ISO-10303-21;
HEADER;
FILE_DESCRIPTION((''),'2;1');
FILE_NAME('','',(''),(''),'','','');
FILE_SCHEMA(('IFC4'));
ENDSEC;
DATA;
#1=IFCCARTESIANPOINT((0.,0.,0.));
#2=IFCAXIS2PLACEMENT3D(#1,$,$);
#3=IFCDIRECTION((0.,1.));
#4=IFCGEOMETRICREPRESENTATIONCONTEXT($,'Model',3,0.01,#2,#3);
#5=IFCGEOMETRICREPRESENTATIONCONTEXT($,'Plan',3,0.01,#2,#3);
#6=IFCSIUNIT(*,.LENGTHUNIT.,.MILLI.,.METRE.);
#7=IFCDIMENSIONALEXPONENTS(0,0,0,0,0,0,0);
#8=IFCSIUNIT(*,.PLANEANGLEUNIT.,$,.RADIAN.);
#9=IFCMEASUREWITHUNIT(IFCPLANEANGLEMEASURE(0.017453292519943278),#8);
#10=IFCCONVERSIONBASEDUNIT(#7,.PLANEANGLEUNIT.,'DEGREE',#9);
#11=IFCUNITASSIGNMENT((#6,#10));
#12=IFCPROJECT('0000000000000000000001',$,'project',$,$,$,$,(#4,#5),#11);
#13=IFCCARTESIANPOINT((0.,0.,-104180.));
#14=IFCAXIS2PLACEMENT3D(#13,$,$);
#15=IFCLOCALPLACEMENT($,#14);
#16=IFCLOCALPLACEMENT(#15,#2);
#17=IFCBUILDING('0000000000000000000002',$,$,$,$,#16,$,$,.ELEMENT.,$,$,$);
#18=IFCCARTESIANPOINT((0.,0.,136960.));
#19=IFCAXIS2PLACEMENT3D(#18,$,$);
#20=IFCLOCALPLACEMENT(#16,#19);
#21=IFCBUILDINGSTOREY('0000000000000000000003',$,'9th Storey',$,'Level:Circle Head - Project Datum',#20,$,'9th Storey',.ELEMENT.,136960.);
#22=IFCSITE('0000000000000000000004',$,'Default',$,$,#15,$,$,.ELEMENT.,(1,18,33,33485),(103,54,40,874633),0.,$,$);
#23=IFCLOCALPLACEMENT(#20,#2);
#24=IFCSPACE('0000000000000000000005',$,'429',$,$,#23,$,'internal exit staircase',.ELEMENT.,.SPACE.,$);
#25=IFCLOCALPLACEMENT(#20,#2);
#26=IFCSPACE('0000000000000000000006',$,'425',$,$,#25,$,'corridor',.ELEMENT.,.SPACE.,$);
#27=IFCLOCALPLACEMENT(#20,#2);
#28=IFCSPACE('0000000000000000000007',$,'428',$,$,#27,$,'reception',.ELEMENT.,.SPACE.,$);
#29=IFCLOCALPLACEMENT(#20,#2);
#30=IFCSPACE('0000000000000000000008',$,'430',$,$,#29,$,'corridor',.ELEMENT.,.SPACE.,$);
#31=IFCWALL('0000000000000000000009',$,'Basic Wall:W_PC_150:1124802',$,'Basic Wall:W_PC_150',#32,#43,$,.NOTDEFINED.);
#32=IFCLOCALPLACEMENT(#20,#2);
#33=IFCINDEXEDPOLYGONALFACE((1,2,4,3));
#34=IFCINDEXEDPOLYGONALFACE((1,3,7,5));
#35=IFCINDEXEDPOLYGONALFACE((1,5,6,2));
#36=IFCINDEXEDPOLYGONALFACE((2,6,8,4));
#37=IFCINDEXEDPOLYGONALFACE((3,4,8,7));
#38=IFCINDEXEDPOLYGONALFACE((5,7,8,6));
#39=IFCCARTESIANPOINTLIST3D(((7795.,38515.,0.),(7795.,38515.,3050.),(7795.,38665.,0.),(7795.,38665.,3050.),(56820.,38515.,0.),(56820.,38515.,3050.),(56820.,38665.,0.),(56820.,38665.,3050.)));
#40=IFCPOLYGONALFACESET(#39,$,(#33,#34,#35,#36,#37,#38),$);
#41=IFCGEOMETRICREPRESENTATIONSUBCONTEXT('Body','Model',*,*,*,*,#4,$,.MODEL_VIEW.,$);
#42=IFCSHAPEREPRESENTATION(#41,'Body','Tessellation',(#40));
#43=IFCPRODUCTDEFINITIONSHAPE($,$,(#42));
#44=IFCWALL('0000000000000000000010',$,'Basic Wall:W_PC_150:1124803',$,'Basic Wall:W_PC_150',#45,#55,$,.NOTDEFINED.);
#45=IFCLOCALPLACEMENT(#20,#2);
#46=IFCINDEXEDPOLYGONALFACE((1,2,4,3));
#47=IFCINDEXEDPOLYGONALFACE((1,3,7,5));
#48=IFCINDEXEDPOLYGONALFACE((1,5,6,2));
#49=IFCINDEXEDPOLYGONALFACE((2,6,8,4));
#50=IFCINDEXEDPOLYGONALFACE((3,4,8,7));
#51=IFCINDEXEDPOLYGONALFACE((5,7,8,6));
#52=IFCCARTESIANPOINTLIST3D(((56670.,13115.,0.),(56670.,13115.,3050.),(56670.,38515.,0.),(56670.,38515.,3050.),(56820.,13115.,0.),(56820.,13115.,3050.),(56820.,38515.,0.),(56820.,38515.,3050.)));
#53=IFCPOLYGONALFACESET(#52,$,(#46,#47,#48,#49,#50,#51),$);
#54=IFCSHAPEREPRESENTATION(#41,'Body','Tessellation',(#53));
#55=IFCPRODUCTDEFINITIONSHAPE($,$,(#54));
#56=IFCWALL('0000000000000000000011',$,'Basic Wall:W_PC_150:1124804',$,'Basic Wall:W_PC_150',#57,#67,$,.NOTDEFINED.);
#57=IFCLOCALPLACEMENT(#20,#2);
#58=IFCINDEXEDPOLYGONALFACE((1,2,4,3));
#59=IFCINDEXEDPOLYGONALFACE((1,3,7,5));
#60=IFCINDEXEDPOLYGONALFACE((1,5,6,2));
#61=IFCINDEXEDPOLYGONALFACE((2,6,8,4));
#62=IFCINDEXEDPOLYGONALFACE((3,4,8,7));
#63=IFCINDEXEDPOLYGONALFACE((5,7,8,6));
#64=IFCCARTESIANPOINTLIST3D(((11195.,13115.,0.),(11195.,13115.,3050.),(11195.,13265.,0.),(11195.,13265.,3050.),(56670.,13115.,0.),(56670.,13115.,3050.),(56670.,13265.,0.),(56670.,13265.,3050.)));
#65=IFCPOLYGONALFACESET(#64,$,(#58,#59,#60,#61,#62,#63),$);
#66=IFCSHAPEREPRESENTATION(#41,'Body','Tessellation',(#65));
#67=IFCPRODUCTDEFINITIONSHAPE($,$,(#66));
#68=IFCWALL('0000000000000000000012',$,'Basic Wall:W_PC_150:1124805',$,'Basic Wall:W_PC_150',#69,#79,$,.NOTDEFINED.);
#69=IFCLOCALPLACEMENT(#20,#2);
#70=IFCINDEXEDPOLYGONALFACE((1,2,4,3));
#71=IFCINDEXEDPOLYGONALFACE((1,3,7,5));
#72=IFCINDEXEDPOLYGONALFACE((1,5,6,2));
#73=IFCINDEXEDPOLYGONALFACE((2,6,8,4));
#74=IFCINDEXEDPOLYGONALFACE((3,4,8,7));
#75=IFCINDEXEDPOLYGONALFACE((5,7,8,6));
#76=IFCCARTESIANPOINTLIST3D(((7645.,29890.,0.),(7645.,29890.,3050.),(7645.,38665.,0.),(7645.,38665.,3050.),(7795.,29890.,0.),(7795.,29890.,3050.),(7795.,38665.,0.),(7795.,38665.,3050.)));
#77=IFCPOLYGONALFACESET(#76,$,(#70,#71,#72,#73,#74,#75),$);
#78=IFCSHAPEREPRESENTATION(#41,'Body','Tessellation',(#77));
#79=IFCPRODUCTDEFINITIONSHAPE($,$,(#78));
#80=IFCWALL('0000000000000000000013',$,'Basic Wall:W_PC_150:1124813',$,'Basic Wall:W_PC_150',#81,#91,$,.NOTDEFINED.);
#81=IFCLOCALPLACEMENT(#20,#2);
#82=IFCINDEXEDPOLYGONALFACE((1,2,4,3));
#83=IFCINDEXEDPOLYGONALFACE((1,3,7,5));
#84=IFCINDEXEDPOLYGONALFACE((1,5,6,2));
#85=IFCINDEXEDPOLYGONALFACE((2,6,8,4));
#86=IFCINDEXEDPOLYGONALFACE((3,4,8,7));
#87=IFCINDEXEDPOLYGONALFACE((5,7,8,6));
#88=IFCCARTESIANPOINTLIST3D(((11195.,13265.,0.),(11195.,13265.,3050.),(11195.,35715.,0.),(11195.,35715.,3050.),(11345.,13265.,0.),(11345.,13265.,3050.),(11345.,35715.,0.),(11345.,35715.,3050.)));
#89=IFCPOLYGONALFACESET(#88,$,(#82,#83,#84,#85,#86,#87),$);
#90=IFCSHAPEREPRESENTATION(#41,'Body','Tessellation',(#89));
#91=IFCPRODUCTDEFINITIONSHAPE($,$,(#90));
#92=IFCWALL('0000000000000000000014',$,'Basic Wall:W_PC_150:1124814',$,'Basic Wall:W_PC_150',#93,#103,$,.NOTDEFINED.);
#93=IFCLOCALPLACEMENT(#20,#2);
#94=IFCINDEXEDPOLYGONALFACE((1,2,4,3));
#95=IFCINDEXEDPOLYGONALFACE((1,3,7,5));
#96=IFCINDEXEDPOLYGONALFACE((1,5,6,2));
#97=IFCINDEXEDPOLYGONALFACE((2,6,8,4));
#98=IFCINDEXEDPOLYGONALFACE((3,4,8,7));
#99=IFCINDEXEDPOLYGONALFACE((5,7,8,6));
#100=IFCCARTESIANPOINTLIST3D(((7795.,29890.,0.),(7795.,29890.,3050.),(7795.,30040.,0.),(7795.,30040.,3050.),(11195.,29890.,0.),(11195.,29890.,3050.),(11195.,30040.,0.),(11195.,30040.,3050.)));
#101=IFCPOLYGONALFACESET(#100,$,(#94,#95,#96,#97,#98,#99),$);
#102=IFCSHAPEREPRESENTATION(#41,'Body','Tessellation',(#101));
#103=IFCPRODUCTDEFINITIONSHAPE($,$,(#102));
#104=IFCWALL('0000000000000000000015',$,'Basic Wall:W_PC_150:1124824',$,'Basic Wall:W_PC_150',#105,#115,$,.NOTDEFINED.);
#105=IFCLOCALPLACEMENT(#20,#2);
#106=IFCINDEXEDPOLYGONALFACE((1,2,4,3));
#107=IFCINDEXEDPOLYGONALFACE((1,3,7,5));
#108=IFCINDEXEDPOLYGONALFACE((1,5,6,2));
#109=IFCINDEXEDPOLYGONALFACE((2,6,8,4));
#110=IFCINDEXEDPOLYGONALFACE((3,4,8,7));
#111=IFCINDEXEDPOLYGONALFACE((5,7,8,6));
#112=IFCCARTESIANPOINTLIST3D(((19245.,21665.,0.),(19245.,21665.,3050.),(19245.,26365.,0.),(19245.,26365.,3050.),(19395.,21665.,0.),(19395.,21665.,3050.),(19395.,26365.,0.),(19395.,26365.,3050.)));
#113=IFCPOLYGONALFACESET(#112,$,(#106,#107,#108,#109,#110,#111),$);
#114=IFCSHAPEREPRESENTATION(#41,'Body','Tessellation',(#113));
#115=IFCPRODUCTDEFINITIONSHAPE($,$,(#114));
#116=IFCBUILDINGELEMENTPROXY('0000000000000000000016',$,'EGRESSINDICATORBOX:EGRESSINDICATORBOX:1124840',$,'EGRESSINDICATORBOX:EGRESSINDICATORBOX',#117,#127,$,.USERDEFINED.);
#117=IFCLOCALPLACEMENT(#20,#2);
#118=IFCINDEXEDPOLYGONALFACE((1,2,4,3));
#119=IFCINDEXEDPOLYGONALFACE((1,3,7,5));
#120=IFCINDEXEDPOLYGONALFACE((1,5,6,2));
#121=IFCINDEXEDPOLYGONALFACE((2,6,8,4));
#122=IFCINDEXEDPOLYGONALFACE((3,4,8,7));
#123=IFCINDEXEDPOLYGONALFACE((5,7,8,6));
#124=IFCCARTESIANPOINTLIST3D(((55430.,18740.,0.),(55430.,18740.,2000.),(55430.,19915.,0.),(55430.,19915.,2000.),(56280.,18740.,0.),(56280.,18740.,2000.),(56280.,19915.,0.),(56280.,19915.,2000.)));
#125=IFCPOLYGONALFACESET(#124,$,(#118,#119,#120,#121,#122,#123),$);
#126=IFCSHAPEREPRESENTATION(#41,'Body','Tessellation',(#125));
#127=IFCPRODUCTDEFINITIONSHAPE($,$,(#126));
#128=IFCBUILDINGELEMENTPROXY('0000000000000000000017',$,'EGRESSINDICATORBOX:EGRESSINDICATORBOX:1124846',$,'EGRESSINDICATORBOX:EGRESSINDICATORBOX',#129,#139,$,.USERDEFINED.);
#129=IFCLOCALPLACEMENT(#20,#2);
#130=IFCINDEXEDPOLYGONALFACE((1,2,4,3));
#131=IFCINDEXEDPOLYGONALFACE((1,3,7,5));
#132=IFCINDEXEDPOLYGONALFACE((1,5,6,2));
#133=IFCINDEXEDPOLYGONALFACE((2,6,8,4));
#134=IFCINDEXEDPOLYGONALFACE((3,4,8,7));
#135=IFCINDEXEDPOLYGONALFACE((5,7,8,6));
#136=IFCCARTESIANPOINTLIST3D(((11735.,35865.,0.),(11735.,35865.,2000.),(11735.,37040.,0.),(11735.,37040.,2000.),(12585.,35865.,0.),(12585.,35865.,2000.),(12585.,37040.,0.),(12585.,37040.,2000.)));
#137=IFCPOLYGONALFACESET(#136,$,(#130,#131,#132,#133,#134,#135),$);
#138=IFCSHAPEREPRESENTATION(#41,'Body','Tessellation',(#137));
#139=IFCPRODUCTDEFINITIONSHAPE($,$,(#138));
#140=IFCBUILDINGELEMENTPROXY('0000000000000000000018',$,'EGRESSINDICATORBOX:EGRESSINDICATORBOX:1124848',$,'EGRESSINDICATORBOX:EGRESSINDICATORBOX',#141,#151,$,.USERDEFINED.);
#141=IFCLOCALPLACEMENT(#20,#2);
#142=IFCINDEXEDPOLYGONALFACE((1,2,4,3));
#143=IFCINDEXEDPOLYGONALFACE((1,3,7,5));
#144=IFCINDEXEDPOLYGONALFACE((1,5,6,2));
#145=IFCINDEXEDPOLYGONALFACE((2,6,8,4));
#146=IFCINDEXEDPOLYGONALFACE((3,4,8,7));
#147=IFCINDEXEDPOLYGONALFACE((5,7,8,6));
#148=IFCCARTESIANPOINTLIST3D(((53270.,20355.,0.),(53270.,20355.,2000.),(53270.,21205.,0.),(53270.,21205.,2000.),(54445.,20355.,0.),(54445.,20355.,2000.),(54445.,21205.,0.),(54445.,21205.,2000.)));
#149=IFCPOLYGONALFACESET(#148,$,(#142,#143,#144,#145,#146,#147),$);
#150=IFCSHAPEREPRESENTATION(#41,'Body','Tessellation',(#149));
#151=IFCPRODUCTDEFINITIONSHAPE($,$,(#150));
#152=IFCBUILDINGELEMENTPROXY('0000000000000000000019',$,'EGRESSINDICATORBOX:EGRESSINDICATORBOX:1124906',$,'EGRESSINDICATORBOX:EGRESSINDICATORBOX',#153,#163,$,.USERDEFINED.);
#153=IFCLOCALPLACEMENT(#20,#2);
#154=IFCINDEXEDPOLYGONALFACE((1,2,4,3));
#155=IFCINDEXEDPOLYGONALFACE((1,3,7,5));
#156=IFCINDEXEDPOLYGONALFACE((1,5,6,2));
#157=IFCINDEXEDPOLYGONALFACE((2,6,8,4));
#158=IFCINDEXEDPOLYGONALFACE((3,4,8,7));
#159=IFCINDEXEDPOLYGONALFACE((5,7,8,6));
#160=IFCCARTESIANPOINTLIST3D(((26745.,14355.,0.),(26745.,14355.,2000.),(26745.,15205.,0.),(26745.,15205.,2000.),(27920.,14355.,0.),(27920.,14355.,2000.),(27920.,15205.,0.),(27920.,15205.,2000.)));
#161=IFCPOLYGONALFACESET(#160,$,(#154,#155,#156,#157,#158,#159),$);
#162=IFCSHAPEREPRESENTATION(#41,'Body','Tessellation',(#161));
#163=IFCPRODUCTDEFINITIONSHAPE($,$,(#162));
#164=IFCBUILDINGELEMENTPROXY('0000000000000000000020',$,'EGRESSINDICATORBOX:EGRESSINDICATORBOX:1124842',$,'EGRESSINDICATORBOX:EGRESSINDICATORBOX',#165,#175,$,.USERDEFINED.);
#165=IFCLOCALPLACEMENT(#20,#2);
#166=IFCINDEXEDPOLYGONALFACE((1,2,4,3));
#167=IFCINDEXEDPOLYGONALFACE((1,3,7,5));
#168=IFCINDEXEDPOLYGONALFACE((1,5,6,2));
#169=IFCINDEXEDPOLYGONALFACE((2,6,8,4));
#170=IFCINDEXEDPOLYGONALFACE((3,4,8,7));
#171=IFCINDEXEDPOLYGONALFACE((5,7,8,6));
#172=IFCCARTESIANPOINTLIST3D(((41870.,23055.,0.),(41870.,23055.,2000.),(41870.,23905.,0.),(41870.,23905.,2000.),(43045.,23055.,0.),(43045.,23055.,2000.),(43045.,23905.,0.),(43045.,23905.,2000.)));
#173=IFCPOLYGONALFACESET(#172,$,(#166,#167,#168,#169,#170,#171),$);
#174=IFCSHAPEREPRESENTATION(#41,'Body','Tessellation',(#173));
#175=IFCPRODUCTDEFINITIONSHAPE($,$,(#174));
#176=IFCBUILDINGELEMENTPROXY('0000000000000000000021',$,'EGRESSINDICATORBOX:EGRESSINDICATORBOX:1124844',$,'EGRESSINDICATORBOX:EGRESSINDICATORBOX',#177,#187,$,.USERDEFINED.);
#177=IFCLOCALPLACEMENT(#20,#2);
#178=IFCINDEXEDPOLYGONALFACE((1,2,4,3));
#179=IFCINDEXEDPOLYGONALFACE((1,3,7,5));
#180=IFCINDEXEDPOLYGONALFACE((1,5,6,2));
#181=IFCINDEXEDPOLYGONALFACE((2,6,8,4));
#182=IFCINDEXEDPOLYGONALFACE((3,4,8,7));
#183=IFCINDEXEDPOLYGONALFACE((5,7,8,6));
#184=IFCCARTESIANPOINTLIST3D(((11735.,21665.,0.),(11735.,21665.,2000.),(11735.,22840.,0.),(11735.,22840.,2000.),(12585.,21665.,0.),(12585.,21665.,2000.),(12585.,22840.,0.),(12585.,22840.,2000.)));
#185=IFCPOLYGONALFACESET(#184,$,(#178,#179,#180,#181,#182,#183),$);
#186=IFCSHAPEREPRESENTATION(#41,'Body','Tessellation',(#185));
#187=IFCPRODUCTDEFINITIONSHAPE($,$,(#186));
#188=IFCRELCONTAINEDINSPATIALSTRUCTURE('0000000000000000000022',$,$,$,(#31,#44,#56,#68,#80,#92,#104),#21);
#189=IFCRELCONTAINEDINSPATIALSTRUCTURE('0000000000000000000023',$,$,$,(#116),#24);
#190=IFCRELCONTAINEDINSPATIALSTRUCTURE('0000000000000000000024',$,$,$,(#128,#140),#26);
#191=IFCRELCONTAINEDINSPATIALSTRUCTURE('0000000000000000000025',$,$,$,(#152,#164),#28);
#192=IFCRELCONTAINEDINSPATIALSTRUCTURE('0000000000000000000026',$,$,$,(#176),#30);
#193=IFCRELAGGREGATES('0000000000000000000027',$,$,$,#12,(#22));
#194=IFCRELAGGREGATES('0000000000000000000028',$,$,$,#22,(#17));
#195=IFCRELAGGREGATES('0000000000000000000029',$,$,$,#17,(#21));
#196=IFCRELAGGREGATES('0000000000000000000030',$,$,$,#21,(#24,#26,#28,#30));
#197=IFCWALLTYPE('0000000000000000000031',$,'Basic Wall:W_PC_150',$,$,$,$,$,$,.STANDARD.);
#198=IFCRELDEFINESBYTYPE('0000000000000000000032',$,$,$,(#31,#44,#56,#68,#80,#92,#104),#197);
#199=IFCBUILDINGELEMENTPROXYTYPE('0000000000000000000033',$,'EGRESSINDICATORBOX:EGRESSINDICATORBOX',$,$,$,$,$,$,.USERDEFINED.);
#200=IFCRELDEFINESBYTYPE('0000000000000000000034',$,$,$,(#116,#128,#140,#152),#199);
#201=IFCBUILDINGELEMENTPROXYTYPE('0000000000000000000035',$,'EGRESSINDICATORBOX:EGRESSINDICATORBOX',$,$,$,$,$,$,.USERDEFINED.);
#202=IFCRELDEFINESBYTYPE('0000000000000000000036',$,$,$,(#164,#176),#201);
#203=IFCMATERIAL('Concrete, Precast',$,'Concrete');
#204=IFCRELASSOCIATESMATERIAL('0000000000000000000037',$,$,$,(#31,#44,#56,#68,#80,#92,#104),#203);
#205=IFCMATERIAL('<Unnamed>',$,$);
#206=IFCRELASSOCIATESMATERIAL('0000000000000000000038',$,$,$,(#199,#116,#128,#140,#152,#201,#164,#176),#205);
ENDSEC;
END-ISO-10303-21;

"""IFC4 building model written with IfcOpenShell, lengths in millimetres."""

from ifc_helpers import new_model, entity, si_unit, converted_unit, direction, frame, origin, place, context, subcontext, project, spatial, indexed_curve, outline, extrude, source, transform, mapped, material, type_object, type_shapes, element, save


model = new_model("IFC4")

# Units and contexts
model_context = context("Model", 3, precision=0.01, world=origin(), true_north=direction((0.0, 1.0)))
plan_context = context("Plan", 3, precision=0.01, world=origin(), true_north=direction((0.0, 1.0)))
body_context = subcontext(model_context, "Body", "Model", "MODEL_VIEW")
ifc_project = project(units=[si_unit("LENGTHUNIT", "METRE", prefix="MILLI"), converted_unit("PLANEANGLEUNIT", "DEGREE", entity("IfcPlaneAngleMeasure", 0.017453292519943278), si_unit("PLANEANGLEUNIT", "RADIAN"), dimensions=[0, 0, 0, 0, 0, 0, 0])], contexts=[model_context, plan_context])

# Site, building, storey
site_placement = place(None, frame((0.0, 0.0, -104180.0)))
site = spatial("IfcSite", under=ifc_project, at=site_placement, Name="Default", CompositionType="ELEMENT", RefLatitude=(1, 18, 33, 33485), RefLongitude=(103, 54, 40, 874633), RefElevation=0.0)
building_placement = place(site_placement, origin())
building = spatial("IfcBuilding", under=site, at=building_placement, CompositionType="ELEMENT")
storey_placement = place(building_placement, frame((0.0, 0.0, 136960.0)))
storey = spatial("IfcBuildingStorey", under=building, at=storey_placement, Name="9th Storey", ObjectType="Level:Circle Head - Project Datum", LongName="9th Storey", CompositionType="ELEMENT", Elevation=136960.0)

# Shared definitions
ifc_material_1 = material(Name="Concrete, Precast", Category="Concrete")

# Walls
wall_type = type_object("IfcWallType", Name="Basic Wall:W_PC_150", PredefinedType="STANDARD")
wall_1_placement = place(storey_placement, frame((56820.0, 38590.0, 0.0), z_axis=(0.0, 0.0, 1.0), x_axis=(-1.0, 0.0, 0.0)))
element("IfcWall", 1, at=wall_1_placement, inside=storey, type_object=wall_type, material=ifc_material_1, Name="Basic Wall:W_PC_150:1124802", ObjectType="Basic Wall:W_PC_150", PredefinedType="NOTDEFINED", context=body_context, shape_type="SweptSolid", body=[
    extrude(outline(indexed_curve([(49025.0, 75.0), (0.0, 75.0), (0.0, -75.0), (49025.0, -75.0), (49025.0, 75.0)], self_intersect=False)), origin(), (0.0, 0.0, 1.0), 3050.0),
])
wall_2_placement = place(storey_placement, frame((56745.0, 13115.0, 0.0), z_axis=(0.0, 0.0, 1.0), x_axis=(0.0, 1.0, 0.0)))
element("IfcWall", 2, at=wall_2_placement, inside=storey, type_object=wall_type, material=ifc_material_1, Name="Basic Wall:W_PC_150:1124803", ObjectType="Basic Wall:W_PC_150", PredefinedType="NOTDEFINED", context=body_context, shape_type="SweptSolid", body=[
    extrude(outline(indexed_curve([(25400.0, 75.0), (0.0, 75.0), (0.0, -75.0), (25400.0, -75.0), (25400.0, 75.0)], self_intersect=False)), origin(), (0.0, 0.0, 1.0), 3050.0),
])
wall_3_placement = place(storey_placement, frame((11195.0, 13190.0, 0.0)))
element("IfcWall", 3, at=wall_3_placement, inside=storey, type_object=wall_type, material=ifc_material_1, Name="Basic Wall:W_PC_150:1124804", ObjectType="Basic Wall:W_PC_150", PredefinedType="NOTDEFINED", context=body_context, shape_type="SweptSolid", body=[
    extrude(outline(indexed_curve([(45475.0, 75.0), (0.0, 75.0), (0.0, -75.0), (45475.0, -75.0), (45475.0, 75.0)], self_intersect=False)), origin(), (0.0, 0.0, 1.0), 3050.0),
])
wall_4_placement = place(storey_placement, frame((7720.0, 38665.0, 0.0), z_axis=(0.0, 0.0, 1.0), x_axis=(0.0, -1.0, 0.0)))
element("IfcWall", 4, at=wall_4_placement, inside=storey, type_object=wall_type, material=ifc_material_1, Name="Basic Wall:W_PC_150:1124805", ObjectType="Basic Wall:W_PC_150", PredefinedType="NOTDEFINED", context=body_context, shape_type="SweptSolid", body=[
    extrude(outline(indexed_curve([(8775.0, 75.0), (0.0, 75.0), (0.0, -75.0), (8775.0, -75.0), (8775.0, 75.0)], self_intersect=False)), origin(), (0.0, 0.0, 1.0), 3050.0),
])
wall_5_placement = place(storey_placement, frame((11270.0, 35715.0, 0.0), z_axis=(0.0, 0.0, 1.0), x_axis=(0.0, -1.0, 0.0)))
element("IfcWall", 5, at=wall_5_placement, inside=storey, type_object=wall_type, material=ifc_material_1, Name="Basic Wall:W_PC_150:1124813", ObjectType="Basic Wall:W_PC_150", PredefinedType="NOTDEFINED", context=body_context, shape_type="SweptSolid", body=[
    extrude(outline(indexed_curve([(22450.0, 75.0), (0.0, 75.0), (0.0, -75.0), (22450.0, -75.0), (22450.0, 75.0)], self_intersect=False)), origin(), (0.0, 0.0, 1.0), 3050.0),
])
wall_6_placement = place(storey_placement, frame((7795.0, 29965.0, 0.0)))
element("IfcWall", 6, at=wall_6_placement, inside=storey, type_object=wall_type, material=ifc_material_1, Name="Basic Wall:W_PC_150:1124814", ObjectType="Basic Wall:W_PC_150", PredefinedType="NOTDEFINED", context=body_context, shape_type="SweptSolid", body=[
    extrude(outline(indexed_curve([(3400.0, 75.0), (0.0, 75.0), (0.0, -75.0), (3400.0, -75.0), (3400.0, 75.0)], self_intersect=False)), origin(), (0.0, 0.0, 1.0), 3050.0),
])
wall_7_placement = place(storey_placement, frame((19320.0, 21665.0, 0.0), z_axis=(0.0, 0.0, 1.0), x_axis=(0.0, 1.0, 0.0)))
element("IfcWall", 7, at=wall_7_placement, inside=storey, type_object=wall_type, material=ifc_material_1, Name="Basic Wall:W_PC_150:1124824", ObjectType="Basic Wall:W_PC_150", PredefinedType="NOTDEFINED", context=body_context, shape_type="SweptSolid", body=[
    extrude(outline(indexed_curve([(4700.0, 75.0), (0.0, 75.0), (0.0, -75.0), (4700.0, -75.0), (4700.0, 75.0)], self_intersect=False)), origin(), (0.0, 0.0, 1.0), 3050.0),
])

# Shared definitions
space_1_placement = place(storey_placement, origin())
space_1 = spatial("IfcSpace", under=storey, at=space_1_placement, Name="429", LongName="internal exit staircase", CompositionType="ELEMENT", PredefinedType="SPACE")

# Building element proxy
ifc_material_2 = material(Name="<Unnamed>")
building_element_proxy_type_1 = type_object("IfcBuildingElementProxyType", Name="EGRESSINDICATORBOX:EGRESSINDICATORBOX", PredefinedType="USERDEFINED", material=ifc_material_2)
shared_shape_1 = source(origin(), body_context, "Body", "SweptSolid", [
    extrude(outline(indexed_curve([(-587.5, -425.0), (587.5, -425.0), (587.5, 425.0), (-587.5, 425.0), (-587.5, -425.0)], self_intersect=False)), frame((0.0, 0.0, 0.0), z_axis=(0.0, 0.0, 1.0), x_axis=(0.0, 1.0, 0.0)), (0.0, 0.0, 1.0), 2000.0),
])
type_shapes(building_element_proxy_type_1, [shared_shape_1])
proxy_1_placement = place(space_1_placement, frame((55855.0, 19327.5, 0.0)))
element("IfcBuildingElementProxy", 8, at=proxy_1_placement, inside=space_1, type_object=building_element_proxy_type_1, material=ifc_material_2, Name="EGRESSINDICATORBOX:EGRESSINDICATORBOX:1124840", ObjectType="EGRESSINDICATORBOX:EGRESSINDICATORBOX", PredefinedType="USERDEFINED", context=body_context, shape_type="MappedRepresentation", body=[
    mapped(shared_shape_1, transform((0.0, 0.0, 0.0), scale=1.0)),
])

# Shared definitions
space_2_placement = place(storey_placement, origin())
space_2 = spatial("IfcSpace", under=storey, at=space_2_placement, Name="425", LongName="corridor", CompositionType="ELEMENT", PredefinedType="SPACE")

# Building element proxies
for number, where, z_axis, x_axis, name in (
    (9, (12160.0, 36452.5, 0.0), (0.0, 0.0, 1.0), (-1.0, 0.0, 0.0), "EGRESSINDICATORBOX:EGRESSINDICATORBOX:1124846"),
    (10, (53857.5, 20780.0, 0.0), (0.0, 0.0, 1.0), (0.0, 1.0, 0.0), "EGRESSINDICATORBOX:EGRESSINDICATORBOX:1124848"),
):
    element("IfcBuildingElementProxy", number, at=place(space_2_placement, frame(where, z_axis=z_axis, x_axis=x_axis)), inside=space_2, type_object=building_element_proxy_type_1, material=ifc_material_2, Name=name, ObjectType="EGRESSINDICATORBOX:EGRESSINDICATORBOX", PredefinedType="USERDEFINED", context=body_context, shape_type="MappedRepresentation", body=[
        mapped(shared_shape_1, transform((0.0, 0.0, 0.0), scale=1.0)),
    ])

# Shared definitions
space_3_placement = place(storey_placement, origin())
space_3 = spatial("IfcSpace", under=storey, at=space_3_placement, Name="428", LongName="reception", CompositionType="ELEMENT", PredefinedType="SPACE")

# Building element proxies
proxy_2_placement = place(space_3_placement, frame((27332.5, 14780.0, 0.0), z_axis=(0.0, 0.0, 1.0), x_axis=(0.0, 1.0, 0.0)))
element("IfcBuildingElementProxy", 11, at=proxy_2_placement, inside=space_3, type_object=building_element_proxy_type_1, material=ifc_material_2, Name="EGRESSINDICATORBOX:EGRESSINDICATORBOX:1124906", ObjectType="EGRESSINDICATORBOX:EGRESSINDICATORBOX", PredefinedType="USERDEFINED", context=body_context, shape_type="MappedRepresentation", body=[
    mapped(shared_shape_1, transform((0.0, 0.0, 0.0), scale=1.0)),
])
building_element_proxy_type_2 = type_object("IfcBuildingElementProxyType", Name="EGRESSINDICATORBOX:EGRESSINDICATORBOX", PredefinedType="USERDEFINED", material=ifc_material_2)
shared_shape_2 = source(origin(), body_context, "Body", "SweptSolid", [
    extrude(outline(indexed_curve([(-425.0, -587.5), (425.0, -587.5), (425.0, 587.5), (-425.0, 587.5), (-425.0, -587.5)], self_intersect=False)), frame((0.0, 0.0, 0.0), z_axis=(0.0, 0.0, 1.0), x_axis=(-1.0, 0.0, 0.0)), (0.0, 0.0, 1.0), 2000.0),
])
type_shapes(building_element_proxy_type_2, [shared_shape_2])
proxy_3_placement = place(space_3_placement, frame((42457.5, 23480.0, 0.0), z_axis=(0.0, 0.0, 1.0), x_axis=(0.0, -1.0, 0.0)))
element("IfcBuildingElementProxy", 12, at=proxy_3_placement, inside=space_3, type_object=building_element_proxy_type_2, material=ifc_material_2, Name="EGRESSINDICATORBOX:EGRESSINDICATORBOX:1124842", ObjectType="EGRESSINDICATORBOX:EGRESSINDICATORBOX", PredefinedType="USERDEFINED", context=body_context, shape_type="MappedRepresentation", body=[
    mapped(shared_shape_2, transform((0.0, 0.0, 0.0), scale=1.0)),
])

# Shared definitions
space_4_placement = place(storey_placement, origin())
space_4 = spatial("IfcSpace", under=storey, at=space_4_placement, Name="430", LongName="corridor", CompositionType="ELEMENT", PredefinedType="SPACE")

# Building element proxy
proxy_4_placement = place(space_4_placement, frame((12160.0, 22252.5, 0.0)))
element("IfcBuildingElementProxy", 13, at=proxy_4_placement, inside=space_4, type_object=building_element_proxy_type_2, material=ifc_material_2, Name="EGRESSINDICATORBOX:EGRESSINDICATORBOX:1124844", ObjectType="EGRESSINDICATORBOX:EGRESSINDICATORBOX", PredefinedType="USERDEFINED", context=body_context, shape_type="MappedRepresentation", body=[
    mapped(shared_shape_2, transform((0.0, 0.0, 0.0), scale=1.0)),
])

save(model, "model.ifc")
